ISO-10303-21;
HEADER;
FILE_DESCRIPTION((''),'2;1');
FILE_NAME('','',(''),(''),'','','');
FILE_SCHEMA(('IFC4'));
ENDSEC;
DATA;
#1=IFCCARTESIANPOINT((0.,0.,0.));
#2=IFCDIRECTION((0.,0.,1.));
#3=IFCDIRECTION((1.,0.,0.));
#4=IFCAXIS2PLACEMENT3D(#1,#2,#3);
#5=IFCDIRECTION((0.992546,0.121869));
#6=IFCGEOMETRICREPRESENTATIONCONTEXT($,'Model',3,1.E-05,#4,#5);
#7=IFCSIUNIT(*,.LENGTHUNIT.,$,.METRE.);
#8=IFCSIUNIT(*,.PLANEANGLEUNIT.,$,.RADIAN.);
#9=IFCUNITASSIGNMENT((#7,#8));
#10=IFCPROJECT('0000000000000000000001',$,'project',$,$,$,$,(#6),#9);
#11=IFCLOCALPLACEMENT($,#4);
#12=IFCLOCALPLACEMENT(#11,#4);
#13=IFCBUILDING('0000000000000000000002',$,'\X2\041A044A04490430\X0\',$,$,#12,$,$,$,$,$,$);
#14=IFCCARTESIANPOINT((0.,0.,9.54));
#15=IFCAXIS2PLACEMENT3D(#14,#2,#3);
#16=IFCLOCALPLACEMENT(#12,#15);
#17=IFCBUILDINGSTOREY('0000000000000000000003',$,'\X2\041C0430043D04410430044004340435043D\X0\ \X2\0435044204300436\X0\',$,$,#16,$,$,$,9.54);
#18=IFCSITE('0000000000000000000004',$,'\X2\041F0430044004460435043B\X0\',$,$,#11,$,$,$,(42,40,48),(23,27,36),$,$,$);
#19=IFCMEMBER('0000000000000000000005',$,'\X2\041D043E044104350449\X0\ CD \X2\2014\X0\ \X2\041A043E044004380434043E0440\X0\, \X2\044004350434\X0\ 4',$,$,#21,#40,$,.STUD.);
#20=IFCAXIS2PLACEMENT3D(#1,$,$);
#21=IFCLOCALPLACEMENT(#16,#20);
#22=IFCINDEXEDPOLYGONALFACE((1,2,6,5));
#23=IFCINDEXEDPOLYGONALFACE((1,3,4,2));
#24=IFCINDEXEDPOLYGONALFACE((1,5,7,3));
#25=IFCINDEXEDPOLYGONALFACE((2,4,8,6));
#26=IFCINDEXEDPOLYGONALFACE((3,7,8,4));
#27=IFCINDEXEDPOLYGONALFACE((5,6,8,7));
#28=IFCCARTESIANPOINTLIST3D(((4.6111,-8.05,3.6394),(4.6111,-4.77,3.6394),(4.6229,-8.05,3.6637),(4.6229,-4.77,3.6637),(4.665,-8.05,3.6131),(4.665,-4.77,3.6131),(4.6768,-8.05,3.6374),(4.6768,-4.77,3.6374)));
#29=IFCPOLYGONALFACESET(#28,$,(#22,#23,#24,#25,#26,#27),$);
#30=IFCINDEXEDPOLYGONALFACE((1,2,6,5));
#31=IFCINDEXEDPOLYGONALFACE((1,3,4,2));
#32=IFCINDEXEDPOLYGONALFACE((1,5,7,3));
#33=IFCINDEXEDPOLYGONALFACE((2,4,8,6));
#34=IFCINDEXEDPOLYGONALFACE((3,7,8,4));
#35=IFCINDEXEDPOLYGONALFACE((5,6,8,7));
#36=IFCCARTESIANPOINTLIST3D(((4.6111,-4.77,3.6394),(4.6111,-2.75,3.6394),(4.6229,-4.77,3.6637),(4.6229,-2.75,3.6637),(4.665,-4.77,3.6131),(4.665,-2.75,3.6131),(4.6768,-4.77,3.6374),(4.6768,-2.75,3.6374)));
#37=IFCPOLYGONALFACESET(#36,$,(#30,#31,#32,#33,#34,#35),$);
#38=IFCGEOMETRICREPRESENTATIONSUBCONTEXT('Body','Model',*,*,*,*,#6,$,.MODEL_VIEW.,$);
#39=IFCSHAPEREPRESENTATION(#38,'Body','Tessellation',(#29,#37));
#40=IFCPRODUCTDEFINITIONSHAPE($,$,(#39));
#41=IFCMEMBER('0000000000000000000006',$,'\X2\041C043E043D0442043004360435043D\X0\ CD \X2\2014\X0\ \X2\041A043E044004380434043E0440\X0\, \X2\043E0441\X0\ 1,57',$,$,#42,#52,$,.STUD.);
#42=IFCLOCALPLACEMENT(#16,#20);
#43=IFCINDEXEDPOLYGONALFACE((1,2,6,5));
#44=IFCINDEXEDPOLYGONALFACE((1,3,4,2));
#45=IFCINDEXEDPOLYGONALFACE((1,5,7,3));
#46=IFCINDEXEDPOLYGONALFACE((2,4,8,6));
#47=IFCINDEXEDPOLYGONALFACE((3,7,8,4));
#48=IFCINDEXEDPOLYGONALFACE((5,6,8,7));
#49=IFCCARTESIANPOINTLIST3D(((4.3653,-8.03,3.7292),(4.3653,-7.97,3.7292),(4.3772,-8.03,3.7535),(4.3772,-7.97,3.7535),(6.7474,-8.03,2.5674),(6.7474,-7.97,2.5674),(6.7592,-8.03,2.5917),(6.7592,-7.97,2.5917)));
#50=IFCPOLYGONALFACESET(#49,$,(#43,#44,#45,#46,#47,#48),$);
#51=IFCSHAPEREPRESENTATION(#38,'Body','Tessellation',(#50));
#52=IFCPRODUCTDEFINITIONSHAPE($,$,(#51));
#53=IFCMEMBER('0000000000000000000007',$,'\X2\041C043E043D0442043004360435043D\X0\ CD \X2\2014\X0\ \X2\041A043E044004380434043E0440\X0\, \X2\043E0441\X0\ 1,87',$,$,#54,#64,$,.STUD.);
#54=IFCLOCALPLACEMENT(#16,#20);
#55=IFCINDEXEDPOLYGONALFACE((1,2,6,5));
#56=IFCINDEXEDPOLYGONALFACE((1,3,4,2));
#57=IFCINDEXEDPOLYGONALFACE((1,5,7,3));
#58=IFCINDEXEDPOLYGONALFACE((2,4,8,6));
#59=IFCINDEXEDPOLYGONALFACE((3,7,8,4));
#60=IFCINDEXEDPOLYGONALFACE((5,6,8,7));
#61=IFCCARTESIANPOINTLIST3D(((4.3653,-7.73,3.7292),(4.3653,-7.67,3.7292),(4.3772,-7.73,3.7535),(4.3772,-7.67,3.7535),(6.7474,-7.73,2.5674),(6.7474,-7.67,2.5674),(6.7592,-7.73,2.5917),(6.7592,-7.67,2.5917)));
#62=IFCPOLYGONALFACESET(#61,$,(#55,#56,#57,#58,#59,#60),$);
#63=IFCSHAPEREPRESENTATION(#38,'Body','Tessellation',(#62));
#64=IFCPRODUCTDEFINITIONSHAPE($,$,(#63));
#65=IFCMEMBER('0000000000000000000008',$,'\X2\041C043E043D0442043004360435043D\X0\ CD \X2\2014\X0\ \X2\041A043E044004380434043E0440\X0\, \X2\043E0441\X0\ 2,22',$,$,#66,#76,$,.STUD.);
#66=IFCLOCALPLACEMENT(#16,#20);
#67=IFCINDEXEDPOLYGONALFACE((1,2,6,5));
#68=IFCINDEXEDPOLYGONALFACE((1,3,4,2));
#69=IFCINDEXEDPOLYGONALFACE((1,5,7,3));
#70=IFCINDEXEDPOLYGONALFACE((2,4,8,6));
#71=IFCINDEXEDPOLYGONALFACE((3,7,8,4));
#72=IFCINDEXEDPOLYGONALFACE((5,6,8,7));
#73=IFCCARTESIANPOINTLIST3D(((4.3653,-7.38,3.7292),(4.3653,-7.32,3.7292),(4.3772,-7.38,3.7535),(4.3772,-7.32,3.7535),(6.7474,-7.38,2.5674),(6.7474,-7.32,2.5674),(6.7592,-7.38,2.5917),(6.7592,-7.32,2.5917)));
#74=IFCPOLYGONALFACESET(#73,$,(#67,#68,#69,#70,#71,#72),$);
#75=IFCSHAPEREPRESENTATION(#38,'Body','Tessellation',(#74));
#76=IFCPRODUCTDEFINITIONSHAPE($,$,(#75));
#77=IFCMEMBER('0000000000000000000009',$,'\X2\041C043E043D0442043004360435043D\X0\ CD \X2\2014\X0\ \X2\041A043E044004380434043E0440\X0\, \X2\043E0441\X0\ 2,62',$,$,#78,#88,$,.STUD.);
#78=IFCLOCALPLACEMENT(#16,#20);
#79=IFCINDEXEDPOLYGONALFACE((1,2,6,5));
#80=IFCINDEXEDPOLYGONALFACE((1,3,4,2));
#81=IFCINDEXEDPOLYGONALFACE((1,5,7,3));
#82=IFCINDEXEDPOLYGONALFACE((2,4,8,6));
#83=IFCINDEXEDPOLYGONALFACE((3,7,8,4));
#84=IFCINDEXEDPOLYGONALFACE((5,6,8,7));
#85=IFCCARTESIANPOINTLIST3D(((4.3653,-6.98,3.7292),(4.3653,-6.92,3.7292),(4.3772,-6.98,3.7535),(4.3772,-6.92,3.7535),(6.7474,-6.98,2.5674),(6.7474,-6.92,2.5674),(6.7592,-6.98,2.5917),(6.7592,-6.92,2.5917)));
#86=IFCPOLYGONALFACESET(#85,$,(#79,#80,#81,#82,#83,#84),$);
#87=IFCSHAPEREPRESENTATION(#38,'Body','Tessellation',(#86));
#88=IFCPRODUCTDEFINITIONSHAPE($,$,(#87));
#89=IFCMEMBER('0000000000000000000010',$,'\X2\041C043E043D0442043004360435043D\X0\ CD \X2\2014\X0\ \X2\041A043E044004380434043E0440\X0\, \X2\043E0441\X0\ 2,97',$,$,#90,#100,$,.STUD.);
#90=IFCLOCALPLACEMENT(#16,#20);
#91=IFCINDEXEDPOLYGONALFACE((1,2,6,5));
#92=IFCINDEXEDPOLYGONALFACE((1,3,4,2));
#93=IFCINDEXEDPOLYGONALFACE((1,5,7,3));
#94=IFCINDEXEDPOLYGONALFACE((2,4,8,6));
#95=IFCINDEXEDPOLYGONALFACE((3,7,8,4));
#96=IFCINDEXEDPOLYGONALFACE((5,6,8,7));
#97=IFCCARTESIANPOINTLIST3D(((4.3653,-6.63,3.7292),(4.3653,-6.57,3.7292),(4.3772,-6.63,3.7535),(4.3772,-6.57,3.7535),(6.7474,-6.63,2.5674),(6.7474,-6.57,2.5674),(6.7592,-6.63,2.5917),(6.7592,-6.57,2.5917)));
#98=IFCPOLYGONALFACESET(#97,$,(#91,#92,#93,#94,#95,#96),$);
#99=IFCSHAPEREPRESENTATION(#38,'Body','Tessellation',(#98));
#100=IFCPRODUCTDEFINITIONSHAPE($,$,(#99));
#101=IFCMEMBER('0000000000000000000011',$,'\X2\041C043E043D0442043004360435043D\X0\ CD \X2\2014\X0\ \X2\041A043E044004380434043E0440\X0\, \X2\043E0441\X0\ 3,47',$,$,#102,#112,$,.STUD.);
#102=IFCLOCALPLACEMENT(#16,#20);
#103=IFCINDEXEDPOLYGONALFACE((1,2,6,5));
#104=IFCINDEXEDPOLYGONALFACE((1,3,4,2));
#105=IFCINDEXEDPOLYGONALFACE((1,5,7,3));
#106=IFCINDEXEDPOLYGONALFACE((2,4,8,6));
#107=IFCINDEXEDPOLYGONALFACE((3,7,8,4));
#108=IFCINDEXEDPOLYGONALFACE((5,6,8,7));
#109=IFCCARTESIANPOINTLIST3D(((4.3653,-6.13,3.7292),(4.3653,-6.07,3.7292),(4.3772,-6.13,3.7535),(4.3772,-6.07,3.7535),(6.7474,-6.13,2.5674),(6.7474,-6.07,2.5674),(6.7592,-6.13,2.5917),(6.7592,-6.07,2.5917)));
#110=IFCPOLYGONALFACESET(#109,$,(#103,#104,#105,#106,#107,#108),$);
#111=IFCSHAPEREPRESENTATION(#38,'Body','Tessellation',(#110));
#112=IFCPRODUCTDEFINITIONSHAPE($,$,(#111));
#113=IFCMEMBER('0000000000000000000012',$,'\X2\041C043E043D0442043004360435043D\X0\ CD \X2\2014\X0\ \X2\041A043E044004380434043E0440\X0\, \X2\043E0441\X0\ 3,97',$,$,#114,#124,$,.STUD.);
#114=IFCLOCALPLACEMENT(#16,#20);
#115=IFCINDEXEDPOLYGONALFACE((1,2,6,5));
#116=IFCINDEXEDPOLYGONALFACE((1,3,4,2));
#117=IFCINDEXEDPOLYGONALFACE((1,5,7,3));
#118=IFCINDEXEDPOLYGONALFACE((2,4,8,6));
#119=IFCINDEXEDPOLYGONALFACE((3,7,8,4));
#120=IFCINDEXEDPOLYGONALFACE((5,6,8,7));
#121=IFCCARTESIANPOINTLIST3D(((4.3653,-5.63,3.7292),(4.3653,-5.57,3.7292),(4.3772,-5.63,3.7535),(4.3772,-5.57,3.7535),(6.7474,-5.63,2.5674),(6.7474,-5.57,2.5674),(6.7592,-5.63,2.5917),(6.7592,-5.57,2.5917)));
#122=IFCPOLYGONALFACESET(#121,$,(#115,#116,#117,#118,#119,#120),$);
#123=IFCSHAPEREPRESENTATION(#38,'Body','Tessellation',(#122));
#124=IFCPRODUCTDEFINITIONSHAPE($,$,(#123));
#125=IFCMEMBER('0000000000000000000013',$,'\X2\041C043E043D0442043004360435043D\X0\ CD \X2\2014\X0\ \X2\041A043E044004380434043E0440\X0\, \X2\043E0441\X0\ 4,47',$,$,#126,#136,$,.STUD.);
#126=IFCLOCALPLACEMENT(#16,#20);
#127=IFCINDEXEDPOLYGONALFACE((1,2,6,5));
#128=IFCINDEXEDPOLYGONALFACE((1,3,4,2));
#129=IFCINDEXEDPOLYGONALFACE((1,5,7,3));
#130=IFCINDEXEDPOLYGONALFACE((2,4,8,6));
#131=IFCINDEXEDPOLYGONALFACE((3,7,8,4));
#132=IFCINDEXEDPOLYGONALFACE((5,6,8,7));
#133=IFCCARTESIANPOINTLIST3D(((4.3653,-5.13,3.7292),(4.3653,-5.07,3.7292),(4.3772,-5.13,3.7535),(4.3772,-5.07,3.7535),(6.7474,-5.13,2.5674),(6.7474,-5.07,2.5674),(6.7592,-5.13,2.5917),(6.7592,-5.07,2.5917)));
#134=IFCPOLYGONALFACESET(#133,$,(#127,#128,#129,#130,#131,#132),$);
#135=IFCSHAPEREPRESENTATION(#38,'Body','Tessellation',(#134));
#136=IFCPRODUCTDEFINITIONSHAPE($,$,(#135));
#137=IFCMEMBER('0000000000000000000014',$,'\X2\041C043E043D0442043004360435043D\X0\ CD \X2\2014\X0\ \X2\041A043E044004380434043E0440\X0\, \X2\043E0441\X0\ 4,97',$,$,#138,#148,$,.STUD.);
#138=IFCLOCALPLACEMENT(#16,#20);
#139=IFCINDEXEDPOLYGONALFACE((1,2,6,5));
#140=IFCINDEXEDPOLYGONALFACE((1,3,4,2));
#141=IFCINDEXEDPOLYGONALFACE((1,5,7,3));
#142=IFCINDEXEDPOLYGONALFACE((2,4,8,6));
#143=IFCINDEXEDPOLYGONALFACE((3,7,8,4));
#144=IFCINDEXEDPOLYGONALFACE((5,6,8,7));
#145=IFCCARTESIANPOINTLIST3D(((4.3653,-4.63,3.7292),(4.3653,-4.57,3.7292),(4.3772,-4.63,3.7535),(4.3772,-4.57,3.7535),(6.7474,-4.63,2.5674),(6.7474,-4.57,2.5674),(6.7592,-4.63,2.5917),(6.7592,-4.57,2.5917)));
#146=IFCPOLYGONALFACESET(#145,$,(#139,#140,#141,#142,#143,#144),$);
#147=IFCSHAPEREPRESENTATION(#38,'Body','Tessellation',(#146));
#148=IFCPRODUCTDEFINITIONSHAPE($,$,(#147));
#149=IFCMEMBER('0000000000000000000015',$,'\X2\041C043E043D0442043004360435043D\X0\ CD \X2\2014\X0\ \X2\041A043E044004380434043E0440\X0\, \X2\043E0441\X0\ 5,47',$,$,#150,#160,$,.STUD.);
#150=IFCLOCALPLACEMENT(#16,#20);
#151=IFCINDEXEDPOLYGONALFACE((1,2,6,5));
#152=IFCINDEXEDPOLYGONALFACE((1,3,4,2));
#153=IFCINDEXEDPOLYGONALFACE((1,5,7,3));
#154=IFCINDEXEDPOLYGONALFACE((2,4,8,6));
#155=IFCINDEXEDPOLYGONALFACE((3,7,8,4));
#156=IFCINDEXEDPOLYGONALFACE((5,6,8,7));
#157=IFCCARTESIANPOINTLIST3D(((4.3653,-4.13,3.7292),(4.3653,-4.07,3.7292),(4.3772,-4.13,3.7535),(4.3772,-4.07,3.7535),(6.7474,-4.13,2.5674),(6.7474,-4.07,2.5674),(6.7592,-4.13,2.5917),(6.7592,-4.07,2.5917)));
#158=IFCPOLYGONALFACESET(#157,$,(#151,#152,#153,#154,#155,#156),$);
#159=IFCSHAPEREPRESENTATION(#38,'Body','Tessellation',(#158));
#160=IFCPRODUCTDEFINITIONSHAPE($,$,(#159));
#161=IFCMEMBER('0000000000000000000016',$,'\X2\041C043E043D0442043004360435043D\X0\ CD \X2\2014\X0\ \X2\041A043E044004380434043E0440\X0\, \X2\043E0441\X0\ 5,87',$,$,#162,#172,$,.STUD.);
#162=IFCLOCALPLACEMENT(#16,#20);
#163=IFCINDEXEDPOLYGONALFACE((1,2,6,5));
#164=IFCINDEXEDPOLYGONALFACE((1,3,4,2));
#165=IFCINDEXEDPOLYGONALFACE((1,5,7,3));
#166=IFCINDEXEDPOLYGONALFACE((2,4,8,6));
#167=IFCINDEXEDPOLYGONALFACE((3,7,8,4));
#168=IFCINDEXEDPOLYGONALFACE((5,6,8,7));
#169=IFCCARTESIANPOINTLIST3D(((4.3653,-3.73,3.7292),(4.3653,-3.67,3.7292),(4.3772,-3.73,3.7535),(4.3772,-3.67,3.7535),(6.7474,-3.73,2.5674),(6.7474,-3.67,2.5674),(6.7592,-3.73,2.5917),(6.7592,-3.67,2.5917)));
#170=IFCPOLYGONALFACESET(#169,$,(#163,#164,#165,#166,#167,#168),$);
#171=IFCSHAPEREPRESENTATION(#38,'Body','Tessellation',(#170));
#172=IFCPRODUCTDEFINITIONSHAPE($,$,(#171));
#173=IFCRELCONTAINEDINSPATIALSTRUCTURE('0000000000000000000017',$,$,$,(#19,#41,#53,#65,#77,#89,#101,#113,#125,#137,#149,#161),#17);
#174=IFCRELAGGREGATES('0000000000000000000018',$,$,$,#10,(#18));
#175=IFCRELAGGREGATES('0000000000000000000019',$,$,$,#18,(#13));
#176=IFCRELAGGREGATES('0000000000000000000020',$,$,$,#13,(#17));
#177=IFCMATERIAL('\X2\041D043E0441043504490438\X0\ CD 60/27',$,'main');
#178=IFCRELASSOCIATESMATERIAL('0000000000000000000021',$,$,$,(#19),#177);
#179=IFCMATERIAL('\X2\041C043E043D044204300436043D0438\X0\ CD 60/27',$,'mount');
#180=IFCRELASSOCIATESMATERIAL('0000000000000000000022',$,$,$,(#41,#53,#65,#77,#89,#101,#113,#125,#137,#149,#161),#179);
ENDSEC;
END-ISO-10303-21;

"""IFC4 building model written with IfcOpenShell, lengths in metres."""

from ifc_helpers import new_model, si_unit, direction, frame, origin_with_axes, place, context, subcontext, project, spatial, polyline, outline, extrude, material, element, save


model = new_model("IFC4")

# Units and contexts
model_context = context("Model", 3, precision=1e-05, world=origin_with_axes(), true_north=direction((0.992546, 0.121869)))
body_context = subcontext(model_context, "Body", "Model", "MODEL_VIEW")
ifc_project = project(units=[si_unit("LENGTHUNIT", "METRE"), si_unit("PLANEANGLEUNIT", "RADIAN")], contexts=[model_context])

# Site, building, storey
site_placement = place(None, origin_with_axes())
site = spatial("IfcSite", under=ifc_project, at=site_placement, Name="Парцел", RefLatitude=(42, 40, 48), RefLongitude=(23, 27, 36))
building_placement = place(site_placement, origin_with_axes())
building = spatial("IfcBuilding", under=site, at=building_placement, Name="Къща")
storey_placement = place(building_placement, frame((0.0, 0.0, 9.54), z_axis=(0.0, 0.0, 1.0), x_axis=(1.0, 0.0, 0.0)))
storey = spatial("IfcBuildingStorey", under=building, at=storey_placement, Name="Мансарден етаж", Elevation=9.54)

# Members
ifc_material_1 = material(Name="Носещи CD 60/27", Category="main")
member_1_placement = place(storey_placement, origin_with_axes())
element("IfcMember", 1, at=member_1_placement, inside=storey, material=ifc_material_1, Name="Носещ CD — Коридор, ред 4", PredefinedType="STUD", context=body_context, shape_type="SweptSolid", body=[
    extrude(outline(polyline([(4.665, -3.6131), (4.6111, -3.6394), (4.6229, -3.6637), (4.6768, -3.6374), (4.665, -3.6131)])), frame((0.0, -8.05, 0.0), z_axis=(0.0, 1.0, 0.0), x_axis=(1.0, 0.0, 0.0)), (0.0, 0.0, 1.0), 3.28),
    extrude(outline(polyline([(4.665, -3.6131), (4.6111, -3.6394), (4.6229, -3.6637), (4.6768, -3.6374), (4.665, -3.6131)])), frame((0.0, -4.77, 0.0), z_axis=(0.0, 1.0, 0.0), x_axis=(1.0, 0.0, 0.0)), (0.0, 0.0, 1.0), 2.02),
])
ifc_material_2 = material(Name="Монтажни CD 60/27", Category="mount")
member_2_placement = place(storey_placement, origin_with_axes())
element("IfcMember", 2, at=member_2_placement, inside=storey, material=ifc_material_2, Name="Монтажен CD — Коридор, ос 1,57", PredefinedType="STUD", context=body_context, shape_type="SweptSolid", body=[
    extrude(outline(polyline([(6.7474, -2.5674), (4.3653, -3.7292), (4.3772, -3.7535), (6.7592, -2.5917), (6.7474, -2.5674)])), frame((0.0, -8.03, 0.0), z_axis=(0.0, 1.0, 0.0), x_axis=(1.0, 0.0, 0.0)), (0.0, 0.0, 1.0), 0.06),
])
member_3_placement = place(storey_placement, origin_with_axes())
element("IfcMember", 3, at=member_3_placement, inside=storey, material=ifc_material_2, Name="Монтажен CD — Коридор, ос 1,87", PredefinedType="STUD", context=body_context, shape_type="SweptSolid", body=[
    extrude(outline(polyline([(6.7474, -2.5674), (4.3653, -3.7292), (4.3772, -3.7535), (6.7592, -2.5917), (6.7474, -2.5674)])), frame((0.0, -7.73, 0.0), z_axis=(0.0, 1.0, 0.0), x_axis=(1.0, 0.0, 0.0)), (0.0, 0.0, 1.0), 0.06),
])
member_4_placement = place(storey_placement, origin_with_axes())
element("IfcMember", 4, at=member_4_placement, inside=storey, material=ifc_material_2, Name="Монтажен CD — Коридор, ос 2,22", PredefinedType="STUD", context=body_context, shape_type="SweptSolid", body=[
    extrude(outline(polyline([(6.7474, -2.5674), (4.3653, -3.7292), (4.3772, -3.7535), (6.7592, -2.5917), (6.7474, -2.5674)])), frame((0.0, -7.38, 0.0), z_axis=(0.0, 1.0, 0.0), x_axis=(1.0, 0.0, 0.0)), (0.0, 0.0, 1.0), 0.06),
])
member_5_placement = place(storey_placement, origin_with_axes())
element("IfcMember", 5, at=member_5_placement, inside=storey, material=ifc_material_2, Name="Монтажен CD — Коридор, ос 2,62", PredefinedType="STUD", context=body_context, shape_type="SweptSolid", body=[
    extrude(outline(polyline([(6.7474, -2.5674), (4.3653, -3.7292), (4.3772, -3.7535), (6.7592, -2.5917), (6.7474, -2.5674)])), frame((0.0, -6.98, 0.0), z_axis=(0.0, 1.0, 0.0), x_axis=(1.0, 0.0, 0.0)), (0.0, 0.0, 1.0), 0.06),
])
member_6_placement = place(storey_placement, origin_with_axes())
element("IfcMember", 6, at=member_6_placement, inside=storey, material=ifc_material_2, Name="Монтажен CD — Коридор, ос 2,97", PredefinedType="STUD", context=body_context, shape_type="SweptSolid", body=[
    extrude(outline(polyline([(6.7474, -2.5674), (4.3653, -3.7292), (4.3772, -3.7535), (6.7592, -2.5917), (6.7474, -2.5674)])), frame((0.0, -6.63, 0.0), z_axis=(0.0, 1.0, 0.0), x_axis=(1.0, 0.0, 0.0)), (0.0, 0.0, 1.0), 0.06),
])
member_7_placement = place(storey_placement, origin_with_axes())
element("IfcMember", 7, at=member_7_placement, inside=storey, material=ifc_material_2, Name="Монтажен CD — Коридор, ос 3,47", PredefinedType="STUD", context=body_context, shape_type="SweptSolid", body=[
    extrude(outline(polyline([(6.7474, -2.5674), (4.3653, -3.7292), (4.3772, -3.7535), (6.7592, -2.5917), (6.7474, -2.5674)])), frame((0.0, -6.13, 0.0), z_axis=(0.0, 1.0, 0.0), x_axis=(1.0, 0.0, 0.0)), (0.0, 0.0, 1.0), 0.06),
])
member_8_placement = place(storey_placement, origin_with_axes())
element("IfcMember", 8, at=member_8_placement, inside=storey, material=ifc_material_2, Name="Монтажен CD — Коридор, ос 3,97", PredefinedType="STUD", context=body_context, shape_type="SweptSolid", body=[
    extrude(outline(polyline([(6.7474, -2.5674), (4.3653, -3.7292), (4.3772, -3.7535), (6.7592, -2.5917), (6.7474, -2.5674)])), frame((0.0, -5.63, 0.0), z_axis=(0.0, 1.0, 0.0), x_axis=(1.0, 0.0, 0.0)), (0.0, 0.0, 1.0), 0.06),
])
member_9_placement = place(storey_placement, origin_with_axes())
element("IfcMember", 9, at=member_9_placement, inside=storey, material=ifc_material_2, Name="Монтажен CD — Коридор, ос 4,47", PredefinedType="STUD", context=body_context, shape_type="SweptSolid", body=[
    extrude(outline(polyline([(6.7474, -2.5674), (4.3653, -3.7292), (4.3772, -3.7535), (6.7592, -2.5917), (6.7474, -2.5674)])), frame((0.0, -5.13, 0.0), z_axis=(0.0, 1.0, 0.0), x_axis=(1.0, 0.0, 0.0)), (0.0, 0.0, 1.0), 0.06),
])
member_10_placement = place(storey_placement, origin_with_axes())
element("IfcMember", 10, at=member_10_placement, inside=storey, material=ifc_material_2, Name="Монтажен CD — Коридор, ос 4,97", PredefinedType="STUD", context=body_context, shape_type="SweptSolid", body=[
    extrude(outline(polyline([(6.7474, -2.5674), (4.3653, -3.7292), (4.3772, -3.7535), (6.7592, -2.5917), (6.7474, -2.5674)])), frame((0.0, -4.63, 0.0), z_axis=(0.0, 1.0, 0.0), x_axis=(1.0, 0.0, 0.0)), (0.0, 0.0, 1.0), 0.06),
])
member_11_placement = place(storey_placement, origin_with_axes())
element("IfcMember", 11, at=member_11_placement, inside=storey, material=ifc_material_2, Name="Монтажен CD — Коридор, ос 5,47", PredefinedType="STUD", context=body_context, shape_type="SweptSolid", body=[
    extrude(outline(polyline([(6.7474, -2.5674), (4.3653, -3.7292), (4.3772, -3.7535), (6.7592, -2.5917), (6.7474, -2.5674)])), frame((0.0, -4.13, 0.0), z_axis=(0.0, 1.0, 0.0), x_axis=(1.0, 0.0, 0.0)), (0.0, 0.0, 1.0), 0.06),
])
member_12_placement = place(storey_placement, origin_with_axes())
element("IfcMember", 12, at=member_12_placement, inside=storey, material=ifc_material_2, Name="Монтажен CD — Коридор, ос 5,87", PredefinedType="STUD", context=body_context, shape_type="SweptSolid", body=[
    extrude(outline(polyline([(6.7474, -2.5674), (4.3653, -3.7292), (4.3772, -3.7535), (6.7592, -2.5917), (6.7474, -2.5674)])), frame((0.0, -3.73, 0.0), z_axis=(0.0, 1.0, 0.0), x_axis=(1.0, 0.0, 0.0)), (0.0, 0.0, 1.0), 0.06),
])

save(model, "model.ifc")
